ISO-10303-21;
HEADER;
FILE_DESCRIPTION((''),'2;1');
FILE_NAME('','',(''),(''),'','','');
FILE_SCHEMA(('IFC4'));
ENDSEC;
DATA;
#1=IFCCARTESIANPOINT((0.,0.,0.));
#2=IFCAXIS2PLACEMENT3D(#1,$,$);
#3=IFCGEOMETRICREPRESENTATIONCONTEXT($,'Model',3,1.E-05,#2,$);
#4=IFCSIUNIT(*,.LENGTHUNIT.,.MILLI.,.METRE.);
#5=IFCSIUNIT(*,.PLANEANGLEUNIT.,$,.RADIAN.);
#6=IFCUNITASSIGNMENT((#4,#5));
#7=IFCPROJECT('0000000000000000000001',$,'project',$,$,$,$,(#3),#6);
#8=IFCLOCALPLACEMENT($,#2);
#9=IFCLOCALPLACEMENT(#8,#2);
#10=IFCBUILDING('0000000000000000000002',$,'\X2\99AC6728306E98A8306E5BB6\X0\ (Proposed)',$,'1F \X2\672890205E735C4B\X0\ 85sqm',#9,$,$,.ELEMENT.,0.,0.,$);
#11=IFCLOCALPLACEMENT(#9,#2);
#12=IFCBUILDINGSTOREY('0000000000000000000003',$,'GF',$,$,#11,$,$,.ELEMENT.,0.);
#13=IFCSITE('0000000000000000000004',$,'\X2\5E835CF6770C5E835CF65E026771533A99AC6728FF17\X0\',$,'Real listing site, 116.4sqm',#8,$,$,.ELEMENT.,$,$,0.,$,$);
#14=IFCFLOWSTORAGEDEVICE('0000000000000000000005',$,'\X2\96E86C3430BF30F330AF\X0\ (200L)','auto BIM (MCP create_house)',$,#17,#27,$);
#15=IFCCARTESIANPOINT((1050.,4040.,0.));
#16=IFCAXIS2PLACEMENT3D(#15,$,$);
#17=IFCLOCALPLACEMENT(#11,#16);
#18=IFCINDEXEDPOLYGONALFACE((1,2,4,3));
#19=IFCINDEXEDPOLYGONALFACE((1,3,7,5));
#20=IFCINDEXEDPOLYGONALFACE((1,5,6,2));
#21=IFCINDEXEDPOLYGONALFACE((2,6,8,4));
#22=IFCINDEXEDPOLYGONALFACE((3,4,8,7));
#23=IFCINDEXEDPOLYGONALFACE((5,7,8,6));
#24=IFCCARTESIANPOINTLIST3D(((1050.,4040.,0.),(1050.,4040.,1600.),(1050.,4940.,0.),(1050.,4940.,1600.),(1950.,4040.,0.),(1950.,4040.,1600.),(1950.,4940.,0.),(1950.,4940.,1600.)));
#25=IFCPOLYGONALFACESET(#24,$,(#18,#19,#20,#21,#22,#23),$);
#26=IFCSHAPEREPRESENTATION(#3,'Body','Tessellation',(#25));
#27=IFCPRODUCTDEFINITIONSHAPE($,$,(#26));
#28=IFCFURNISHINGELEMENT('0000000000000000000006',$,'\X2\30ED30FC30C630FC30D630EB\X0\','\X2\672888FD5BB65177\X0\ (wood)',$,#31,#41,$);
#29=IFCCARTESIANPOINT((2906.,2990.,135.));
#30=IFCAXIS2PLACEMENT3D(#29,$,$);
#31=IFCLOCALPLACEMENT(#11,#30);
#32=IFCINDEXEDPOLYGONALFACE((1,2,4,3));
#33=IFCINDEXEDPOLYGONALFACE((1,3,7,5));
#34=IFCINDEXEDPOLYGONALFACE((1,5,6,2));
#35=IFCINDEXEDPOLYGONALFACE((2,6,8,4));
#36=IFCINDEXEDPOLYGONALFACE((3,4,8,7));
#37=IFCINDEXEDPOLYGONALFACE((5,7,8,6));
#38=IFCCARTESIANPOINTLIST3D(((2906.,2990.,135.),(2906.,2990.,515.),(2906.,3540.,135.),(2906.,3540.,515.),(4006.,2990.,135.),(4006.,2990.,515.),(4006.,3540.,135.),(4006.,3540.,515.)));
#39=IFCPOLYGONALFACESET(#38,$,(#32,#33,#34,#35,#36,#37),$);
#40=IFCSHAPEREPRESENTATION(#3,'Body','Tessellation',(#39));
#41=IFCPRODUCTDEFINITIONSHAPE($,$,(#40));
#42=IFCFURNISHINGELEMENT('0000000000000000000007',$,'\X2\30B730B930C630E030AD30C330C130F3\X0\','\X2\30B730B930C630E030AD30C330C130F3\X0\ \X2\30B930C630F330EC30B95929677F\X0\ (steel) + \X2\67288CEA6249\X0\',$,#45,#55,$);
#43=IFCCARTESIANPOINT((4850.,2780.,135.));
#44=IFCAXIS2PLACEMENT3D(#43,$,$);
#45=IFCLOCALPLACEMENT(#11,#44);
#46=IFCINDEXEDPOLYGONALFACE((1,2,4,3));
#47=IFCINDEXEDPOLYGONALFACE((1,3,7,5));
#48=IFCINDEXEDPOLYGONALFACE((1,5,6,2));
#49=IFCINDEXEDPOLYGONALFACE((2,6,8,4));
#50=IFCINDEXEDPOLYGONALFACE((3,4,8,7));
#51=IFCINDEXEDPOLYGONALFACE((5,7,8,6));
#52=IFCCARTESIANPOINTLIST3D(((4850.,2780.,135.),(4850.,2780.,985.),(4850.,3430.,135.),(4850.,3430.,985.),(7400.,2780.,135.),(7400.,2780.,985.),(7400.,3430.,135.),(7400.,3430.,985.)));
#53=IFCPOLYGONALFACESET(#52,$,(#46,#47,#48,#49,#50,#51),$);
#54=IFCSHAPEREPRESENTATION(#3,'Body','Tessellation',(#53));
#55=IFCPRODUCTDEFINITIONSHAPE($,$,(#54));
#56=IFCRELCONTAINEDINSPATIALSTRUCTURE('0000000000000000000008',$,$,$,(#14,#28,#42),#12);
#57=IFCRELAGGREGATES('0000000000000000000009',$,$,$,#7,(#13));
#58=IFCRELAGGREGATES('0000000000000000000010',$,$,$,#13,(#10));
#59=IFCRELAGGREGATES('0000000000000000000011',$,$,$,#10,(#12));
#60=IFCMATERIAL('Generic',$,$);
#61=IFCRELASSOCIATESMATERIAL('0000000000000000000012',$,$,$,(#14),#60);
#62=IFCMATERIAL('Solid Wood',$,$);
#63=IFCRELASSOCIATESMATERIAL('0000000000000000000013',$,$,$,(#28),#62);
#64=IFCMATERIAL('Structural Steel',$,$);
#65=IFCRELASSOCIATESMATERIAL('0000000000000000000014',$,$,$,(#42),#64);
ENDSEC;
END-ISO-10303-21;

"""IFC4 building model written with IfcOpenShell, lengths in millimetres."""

from ifc_helpers import new_model, si_unit, frame, frame_2d, origin, place, context, project, spatial, rectangle, extrude, material, element, save


model = new_model("IFC4")

# Units and contexts
model_context = context("Model", 3, precision=1e-05, world=origin())
ifc_project = project(units=[si_unit("LENGTHUNIT", "METRE", prefix="MILLI"), si_unit("PLANEANGLEUNIT", "RADIAN")], contexts=[model_context])

# Site, building, storey
site_placement = place(None, origin())
site = spatial("IfcSite", under=ifc_project, at=site_placement, Name="広島県広島市東区馬木７", ObjectType="Real listing site, 116.4sqm", CompositionType="ELEMENT", RefElevation=0.0)
building_placement = place(site_placement, origin())
building = spatial("IfcBuilding", under=site, at=building_placement, Name="馬木の風の家 (Proposed)", ObjectType="1F 木造平屋 85sqm", CompositionType="ELEMENT", ElevationOfRefHeight=0.0, ElevationOfTerrain=0.0)
storey_placement = place(building_placement, origin())
storey = spatial("IfcBuildingStorey", under=building, at=storey_placement, Name="GF", CompositionType="ELEMENT", Elevation=0.0)

# Shared definitions
ifc_material_1 = material(Name="Solid Wood")

# Shared definitions
ifc_material_2 = material(Name="Generic")

# Flow storage device
flow_storage_device_placement = place(storey_placement, frame((1050.0, 4040.0, 0.0)))
element("IfcFlowStorageDevice", 1, at=flow_storage_device_placement, inside=storey, material=ifc_material_2, Name="雨水タンク (200L)", Description="auto BIM (MCP create_house)", context=model_context, shape_type="SweptSolid", body=[
    extrude(rectangle(XDim=900.0, YDim=900.0, at=frame_2d((450.0, 450.0))), frame((1050.0, 4040.0, 0.0)), (0.0, 0.0, 1.0), 1600.0),
])

# Furnishing elements
furnishing_1_placement = place(storey_placement, frame((2906.0, 2990.0, 135.0)))
element("IfcFurnishingElement", 2, at=furnishing_1_placement, inside=storey, material=ifc_material_1, Name="ローテーブル", Description="木製家具 (wood)", context=model_context, shape_type="SweptSolid", body=[
    extrude(rectangle(XDim=1100.0, YDim=550.0, at=frame_2d((550.0, 275.0))), frame((2906.0, 2990.0, 135.0)), (0.0, 0.0, 1.0), 380.0),
])
ifc_material_3 = material(Name="Structural Steel")
furnishing_2_placement = place(storey_placement, frame((4850.0, 2780.0, 135.0)))
element("IfcFurnishingElement", 3, at=furnishing_2_placement, inside=storey, material=ifc_material_3, Name="システムキッチン", Description="システムキッチン ステンレス天板 (steel) + 木質扉", context=model_context, shape_type="SweptSolid", body=[
    extrude(rectangle(XDim=2550.0, YDim=650.0, at=frame_2d((1275.0, 325.0))), frame((4850.0, 2780.0, 135.0)), (0.0, 0.0, 1.0), 850.0),
])

save(model, "model.ifc")
